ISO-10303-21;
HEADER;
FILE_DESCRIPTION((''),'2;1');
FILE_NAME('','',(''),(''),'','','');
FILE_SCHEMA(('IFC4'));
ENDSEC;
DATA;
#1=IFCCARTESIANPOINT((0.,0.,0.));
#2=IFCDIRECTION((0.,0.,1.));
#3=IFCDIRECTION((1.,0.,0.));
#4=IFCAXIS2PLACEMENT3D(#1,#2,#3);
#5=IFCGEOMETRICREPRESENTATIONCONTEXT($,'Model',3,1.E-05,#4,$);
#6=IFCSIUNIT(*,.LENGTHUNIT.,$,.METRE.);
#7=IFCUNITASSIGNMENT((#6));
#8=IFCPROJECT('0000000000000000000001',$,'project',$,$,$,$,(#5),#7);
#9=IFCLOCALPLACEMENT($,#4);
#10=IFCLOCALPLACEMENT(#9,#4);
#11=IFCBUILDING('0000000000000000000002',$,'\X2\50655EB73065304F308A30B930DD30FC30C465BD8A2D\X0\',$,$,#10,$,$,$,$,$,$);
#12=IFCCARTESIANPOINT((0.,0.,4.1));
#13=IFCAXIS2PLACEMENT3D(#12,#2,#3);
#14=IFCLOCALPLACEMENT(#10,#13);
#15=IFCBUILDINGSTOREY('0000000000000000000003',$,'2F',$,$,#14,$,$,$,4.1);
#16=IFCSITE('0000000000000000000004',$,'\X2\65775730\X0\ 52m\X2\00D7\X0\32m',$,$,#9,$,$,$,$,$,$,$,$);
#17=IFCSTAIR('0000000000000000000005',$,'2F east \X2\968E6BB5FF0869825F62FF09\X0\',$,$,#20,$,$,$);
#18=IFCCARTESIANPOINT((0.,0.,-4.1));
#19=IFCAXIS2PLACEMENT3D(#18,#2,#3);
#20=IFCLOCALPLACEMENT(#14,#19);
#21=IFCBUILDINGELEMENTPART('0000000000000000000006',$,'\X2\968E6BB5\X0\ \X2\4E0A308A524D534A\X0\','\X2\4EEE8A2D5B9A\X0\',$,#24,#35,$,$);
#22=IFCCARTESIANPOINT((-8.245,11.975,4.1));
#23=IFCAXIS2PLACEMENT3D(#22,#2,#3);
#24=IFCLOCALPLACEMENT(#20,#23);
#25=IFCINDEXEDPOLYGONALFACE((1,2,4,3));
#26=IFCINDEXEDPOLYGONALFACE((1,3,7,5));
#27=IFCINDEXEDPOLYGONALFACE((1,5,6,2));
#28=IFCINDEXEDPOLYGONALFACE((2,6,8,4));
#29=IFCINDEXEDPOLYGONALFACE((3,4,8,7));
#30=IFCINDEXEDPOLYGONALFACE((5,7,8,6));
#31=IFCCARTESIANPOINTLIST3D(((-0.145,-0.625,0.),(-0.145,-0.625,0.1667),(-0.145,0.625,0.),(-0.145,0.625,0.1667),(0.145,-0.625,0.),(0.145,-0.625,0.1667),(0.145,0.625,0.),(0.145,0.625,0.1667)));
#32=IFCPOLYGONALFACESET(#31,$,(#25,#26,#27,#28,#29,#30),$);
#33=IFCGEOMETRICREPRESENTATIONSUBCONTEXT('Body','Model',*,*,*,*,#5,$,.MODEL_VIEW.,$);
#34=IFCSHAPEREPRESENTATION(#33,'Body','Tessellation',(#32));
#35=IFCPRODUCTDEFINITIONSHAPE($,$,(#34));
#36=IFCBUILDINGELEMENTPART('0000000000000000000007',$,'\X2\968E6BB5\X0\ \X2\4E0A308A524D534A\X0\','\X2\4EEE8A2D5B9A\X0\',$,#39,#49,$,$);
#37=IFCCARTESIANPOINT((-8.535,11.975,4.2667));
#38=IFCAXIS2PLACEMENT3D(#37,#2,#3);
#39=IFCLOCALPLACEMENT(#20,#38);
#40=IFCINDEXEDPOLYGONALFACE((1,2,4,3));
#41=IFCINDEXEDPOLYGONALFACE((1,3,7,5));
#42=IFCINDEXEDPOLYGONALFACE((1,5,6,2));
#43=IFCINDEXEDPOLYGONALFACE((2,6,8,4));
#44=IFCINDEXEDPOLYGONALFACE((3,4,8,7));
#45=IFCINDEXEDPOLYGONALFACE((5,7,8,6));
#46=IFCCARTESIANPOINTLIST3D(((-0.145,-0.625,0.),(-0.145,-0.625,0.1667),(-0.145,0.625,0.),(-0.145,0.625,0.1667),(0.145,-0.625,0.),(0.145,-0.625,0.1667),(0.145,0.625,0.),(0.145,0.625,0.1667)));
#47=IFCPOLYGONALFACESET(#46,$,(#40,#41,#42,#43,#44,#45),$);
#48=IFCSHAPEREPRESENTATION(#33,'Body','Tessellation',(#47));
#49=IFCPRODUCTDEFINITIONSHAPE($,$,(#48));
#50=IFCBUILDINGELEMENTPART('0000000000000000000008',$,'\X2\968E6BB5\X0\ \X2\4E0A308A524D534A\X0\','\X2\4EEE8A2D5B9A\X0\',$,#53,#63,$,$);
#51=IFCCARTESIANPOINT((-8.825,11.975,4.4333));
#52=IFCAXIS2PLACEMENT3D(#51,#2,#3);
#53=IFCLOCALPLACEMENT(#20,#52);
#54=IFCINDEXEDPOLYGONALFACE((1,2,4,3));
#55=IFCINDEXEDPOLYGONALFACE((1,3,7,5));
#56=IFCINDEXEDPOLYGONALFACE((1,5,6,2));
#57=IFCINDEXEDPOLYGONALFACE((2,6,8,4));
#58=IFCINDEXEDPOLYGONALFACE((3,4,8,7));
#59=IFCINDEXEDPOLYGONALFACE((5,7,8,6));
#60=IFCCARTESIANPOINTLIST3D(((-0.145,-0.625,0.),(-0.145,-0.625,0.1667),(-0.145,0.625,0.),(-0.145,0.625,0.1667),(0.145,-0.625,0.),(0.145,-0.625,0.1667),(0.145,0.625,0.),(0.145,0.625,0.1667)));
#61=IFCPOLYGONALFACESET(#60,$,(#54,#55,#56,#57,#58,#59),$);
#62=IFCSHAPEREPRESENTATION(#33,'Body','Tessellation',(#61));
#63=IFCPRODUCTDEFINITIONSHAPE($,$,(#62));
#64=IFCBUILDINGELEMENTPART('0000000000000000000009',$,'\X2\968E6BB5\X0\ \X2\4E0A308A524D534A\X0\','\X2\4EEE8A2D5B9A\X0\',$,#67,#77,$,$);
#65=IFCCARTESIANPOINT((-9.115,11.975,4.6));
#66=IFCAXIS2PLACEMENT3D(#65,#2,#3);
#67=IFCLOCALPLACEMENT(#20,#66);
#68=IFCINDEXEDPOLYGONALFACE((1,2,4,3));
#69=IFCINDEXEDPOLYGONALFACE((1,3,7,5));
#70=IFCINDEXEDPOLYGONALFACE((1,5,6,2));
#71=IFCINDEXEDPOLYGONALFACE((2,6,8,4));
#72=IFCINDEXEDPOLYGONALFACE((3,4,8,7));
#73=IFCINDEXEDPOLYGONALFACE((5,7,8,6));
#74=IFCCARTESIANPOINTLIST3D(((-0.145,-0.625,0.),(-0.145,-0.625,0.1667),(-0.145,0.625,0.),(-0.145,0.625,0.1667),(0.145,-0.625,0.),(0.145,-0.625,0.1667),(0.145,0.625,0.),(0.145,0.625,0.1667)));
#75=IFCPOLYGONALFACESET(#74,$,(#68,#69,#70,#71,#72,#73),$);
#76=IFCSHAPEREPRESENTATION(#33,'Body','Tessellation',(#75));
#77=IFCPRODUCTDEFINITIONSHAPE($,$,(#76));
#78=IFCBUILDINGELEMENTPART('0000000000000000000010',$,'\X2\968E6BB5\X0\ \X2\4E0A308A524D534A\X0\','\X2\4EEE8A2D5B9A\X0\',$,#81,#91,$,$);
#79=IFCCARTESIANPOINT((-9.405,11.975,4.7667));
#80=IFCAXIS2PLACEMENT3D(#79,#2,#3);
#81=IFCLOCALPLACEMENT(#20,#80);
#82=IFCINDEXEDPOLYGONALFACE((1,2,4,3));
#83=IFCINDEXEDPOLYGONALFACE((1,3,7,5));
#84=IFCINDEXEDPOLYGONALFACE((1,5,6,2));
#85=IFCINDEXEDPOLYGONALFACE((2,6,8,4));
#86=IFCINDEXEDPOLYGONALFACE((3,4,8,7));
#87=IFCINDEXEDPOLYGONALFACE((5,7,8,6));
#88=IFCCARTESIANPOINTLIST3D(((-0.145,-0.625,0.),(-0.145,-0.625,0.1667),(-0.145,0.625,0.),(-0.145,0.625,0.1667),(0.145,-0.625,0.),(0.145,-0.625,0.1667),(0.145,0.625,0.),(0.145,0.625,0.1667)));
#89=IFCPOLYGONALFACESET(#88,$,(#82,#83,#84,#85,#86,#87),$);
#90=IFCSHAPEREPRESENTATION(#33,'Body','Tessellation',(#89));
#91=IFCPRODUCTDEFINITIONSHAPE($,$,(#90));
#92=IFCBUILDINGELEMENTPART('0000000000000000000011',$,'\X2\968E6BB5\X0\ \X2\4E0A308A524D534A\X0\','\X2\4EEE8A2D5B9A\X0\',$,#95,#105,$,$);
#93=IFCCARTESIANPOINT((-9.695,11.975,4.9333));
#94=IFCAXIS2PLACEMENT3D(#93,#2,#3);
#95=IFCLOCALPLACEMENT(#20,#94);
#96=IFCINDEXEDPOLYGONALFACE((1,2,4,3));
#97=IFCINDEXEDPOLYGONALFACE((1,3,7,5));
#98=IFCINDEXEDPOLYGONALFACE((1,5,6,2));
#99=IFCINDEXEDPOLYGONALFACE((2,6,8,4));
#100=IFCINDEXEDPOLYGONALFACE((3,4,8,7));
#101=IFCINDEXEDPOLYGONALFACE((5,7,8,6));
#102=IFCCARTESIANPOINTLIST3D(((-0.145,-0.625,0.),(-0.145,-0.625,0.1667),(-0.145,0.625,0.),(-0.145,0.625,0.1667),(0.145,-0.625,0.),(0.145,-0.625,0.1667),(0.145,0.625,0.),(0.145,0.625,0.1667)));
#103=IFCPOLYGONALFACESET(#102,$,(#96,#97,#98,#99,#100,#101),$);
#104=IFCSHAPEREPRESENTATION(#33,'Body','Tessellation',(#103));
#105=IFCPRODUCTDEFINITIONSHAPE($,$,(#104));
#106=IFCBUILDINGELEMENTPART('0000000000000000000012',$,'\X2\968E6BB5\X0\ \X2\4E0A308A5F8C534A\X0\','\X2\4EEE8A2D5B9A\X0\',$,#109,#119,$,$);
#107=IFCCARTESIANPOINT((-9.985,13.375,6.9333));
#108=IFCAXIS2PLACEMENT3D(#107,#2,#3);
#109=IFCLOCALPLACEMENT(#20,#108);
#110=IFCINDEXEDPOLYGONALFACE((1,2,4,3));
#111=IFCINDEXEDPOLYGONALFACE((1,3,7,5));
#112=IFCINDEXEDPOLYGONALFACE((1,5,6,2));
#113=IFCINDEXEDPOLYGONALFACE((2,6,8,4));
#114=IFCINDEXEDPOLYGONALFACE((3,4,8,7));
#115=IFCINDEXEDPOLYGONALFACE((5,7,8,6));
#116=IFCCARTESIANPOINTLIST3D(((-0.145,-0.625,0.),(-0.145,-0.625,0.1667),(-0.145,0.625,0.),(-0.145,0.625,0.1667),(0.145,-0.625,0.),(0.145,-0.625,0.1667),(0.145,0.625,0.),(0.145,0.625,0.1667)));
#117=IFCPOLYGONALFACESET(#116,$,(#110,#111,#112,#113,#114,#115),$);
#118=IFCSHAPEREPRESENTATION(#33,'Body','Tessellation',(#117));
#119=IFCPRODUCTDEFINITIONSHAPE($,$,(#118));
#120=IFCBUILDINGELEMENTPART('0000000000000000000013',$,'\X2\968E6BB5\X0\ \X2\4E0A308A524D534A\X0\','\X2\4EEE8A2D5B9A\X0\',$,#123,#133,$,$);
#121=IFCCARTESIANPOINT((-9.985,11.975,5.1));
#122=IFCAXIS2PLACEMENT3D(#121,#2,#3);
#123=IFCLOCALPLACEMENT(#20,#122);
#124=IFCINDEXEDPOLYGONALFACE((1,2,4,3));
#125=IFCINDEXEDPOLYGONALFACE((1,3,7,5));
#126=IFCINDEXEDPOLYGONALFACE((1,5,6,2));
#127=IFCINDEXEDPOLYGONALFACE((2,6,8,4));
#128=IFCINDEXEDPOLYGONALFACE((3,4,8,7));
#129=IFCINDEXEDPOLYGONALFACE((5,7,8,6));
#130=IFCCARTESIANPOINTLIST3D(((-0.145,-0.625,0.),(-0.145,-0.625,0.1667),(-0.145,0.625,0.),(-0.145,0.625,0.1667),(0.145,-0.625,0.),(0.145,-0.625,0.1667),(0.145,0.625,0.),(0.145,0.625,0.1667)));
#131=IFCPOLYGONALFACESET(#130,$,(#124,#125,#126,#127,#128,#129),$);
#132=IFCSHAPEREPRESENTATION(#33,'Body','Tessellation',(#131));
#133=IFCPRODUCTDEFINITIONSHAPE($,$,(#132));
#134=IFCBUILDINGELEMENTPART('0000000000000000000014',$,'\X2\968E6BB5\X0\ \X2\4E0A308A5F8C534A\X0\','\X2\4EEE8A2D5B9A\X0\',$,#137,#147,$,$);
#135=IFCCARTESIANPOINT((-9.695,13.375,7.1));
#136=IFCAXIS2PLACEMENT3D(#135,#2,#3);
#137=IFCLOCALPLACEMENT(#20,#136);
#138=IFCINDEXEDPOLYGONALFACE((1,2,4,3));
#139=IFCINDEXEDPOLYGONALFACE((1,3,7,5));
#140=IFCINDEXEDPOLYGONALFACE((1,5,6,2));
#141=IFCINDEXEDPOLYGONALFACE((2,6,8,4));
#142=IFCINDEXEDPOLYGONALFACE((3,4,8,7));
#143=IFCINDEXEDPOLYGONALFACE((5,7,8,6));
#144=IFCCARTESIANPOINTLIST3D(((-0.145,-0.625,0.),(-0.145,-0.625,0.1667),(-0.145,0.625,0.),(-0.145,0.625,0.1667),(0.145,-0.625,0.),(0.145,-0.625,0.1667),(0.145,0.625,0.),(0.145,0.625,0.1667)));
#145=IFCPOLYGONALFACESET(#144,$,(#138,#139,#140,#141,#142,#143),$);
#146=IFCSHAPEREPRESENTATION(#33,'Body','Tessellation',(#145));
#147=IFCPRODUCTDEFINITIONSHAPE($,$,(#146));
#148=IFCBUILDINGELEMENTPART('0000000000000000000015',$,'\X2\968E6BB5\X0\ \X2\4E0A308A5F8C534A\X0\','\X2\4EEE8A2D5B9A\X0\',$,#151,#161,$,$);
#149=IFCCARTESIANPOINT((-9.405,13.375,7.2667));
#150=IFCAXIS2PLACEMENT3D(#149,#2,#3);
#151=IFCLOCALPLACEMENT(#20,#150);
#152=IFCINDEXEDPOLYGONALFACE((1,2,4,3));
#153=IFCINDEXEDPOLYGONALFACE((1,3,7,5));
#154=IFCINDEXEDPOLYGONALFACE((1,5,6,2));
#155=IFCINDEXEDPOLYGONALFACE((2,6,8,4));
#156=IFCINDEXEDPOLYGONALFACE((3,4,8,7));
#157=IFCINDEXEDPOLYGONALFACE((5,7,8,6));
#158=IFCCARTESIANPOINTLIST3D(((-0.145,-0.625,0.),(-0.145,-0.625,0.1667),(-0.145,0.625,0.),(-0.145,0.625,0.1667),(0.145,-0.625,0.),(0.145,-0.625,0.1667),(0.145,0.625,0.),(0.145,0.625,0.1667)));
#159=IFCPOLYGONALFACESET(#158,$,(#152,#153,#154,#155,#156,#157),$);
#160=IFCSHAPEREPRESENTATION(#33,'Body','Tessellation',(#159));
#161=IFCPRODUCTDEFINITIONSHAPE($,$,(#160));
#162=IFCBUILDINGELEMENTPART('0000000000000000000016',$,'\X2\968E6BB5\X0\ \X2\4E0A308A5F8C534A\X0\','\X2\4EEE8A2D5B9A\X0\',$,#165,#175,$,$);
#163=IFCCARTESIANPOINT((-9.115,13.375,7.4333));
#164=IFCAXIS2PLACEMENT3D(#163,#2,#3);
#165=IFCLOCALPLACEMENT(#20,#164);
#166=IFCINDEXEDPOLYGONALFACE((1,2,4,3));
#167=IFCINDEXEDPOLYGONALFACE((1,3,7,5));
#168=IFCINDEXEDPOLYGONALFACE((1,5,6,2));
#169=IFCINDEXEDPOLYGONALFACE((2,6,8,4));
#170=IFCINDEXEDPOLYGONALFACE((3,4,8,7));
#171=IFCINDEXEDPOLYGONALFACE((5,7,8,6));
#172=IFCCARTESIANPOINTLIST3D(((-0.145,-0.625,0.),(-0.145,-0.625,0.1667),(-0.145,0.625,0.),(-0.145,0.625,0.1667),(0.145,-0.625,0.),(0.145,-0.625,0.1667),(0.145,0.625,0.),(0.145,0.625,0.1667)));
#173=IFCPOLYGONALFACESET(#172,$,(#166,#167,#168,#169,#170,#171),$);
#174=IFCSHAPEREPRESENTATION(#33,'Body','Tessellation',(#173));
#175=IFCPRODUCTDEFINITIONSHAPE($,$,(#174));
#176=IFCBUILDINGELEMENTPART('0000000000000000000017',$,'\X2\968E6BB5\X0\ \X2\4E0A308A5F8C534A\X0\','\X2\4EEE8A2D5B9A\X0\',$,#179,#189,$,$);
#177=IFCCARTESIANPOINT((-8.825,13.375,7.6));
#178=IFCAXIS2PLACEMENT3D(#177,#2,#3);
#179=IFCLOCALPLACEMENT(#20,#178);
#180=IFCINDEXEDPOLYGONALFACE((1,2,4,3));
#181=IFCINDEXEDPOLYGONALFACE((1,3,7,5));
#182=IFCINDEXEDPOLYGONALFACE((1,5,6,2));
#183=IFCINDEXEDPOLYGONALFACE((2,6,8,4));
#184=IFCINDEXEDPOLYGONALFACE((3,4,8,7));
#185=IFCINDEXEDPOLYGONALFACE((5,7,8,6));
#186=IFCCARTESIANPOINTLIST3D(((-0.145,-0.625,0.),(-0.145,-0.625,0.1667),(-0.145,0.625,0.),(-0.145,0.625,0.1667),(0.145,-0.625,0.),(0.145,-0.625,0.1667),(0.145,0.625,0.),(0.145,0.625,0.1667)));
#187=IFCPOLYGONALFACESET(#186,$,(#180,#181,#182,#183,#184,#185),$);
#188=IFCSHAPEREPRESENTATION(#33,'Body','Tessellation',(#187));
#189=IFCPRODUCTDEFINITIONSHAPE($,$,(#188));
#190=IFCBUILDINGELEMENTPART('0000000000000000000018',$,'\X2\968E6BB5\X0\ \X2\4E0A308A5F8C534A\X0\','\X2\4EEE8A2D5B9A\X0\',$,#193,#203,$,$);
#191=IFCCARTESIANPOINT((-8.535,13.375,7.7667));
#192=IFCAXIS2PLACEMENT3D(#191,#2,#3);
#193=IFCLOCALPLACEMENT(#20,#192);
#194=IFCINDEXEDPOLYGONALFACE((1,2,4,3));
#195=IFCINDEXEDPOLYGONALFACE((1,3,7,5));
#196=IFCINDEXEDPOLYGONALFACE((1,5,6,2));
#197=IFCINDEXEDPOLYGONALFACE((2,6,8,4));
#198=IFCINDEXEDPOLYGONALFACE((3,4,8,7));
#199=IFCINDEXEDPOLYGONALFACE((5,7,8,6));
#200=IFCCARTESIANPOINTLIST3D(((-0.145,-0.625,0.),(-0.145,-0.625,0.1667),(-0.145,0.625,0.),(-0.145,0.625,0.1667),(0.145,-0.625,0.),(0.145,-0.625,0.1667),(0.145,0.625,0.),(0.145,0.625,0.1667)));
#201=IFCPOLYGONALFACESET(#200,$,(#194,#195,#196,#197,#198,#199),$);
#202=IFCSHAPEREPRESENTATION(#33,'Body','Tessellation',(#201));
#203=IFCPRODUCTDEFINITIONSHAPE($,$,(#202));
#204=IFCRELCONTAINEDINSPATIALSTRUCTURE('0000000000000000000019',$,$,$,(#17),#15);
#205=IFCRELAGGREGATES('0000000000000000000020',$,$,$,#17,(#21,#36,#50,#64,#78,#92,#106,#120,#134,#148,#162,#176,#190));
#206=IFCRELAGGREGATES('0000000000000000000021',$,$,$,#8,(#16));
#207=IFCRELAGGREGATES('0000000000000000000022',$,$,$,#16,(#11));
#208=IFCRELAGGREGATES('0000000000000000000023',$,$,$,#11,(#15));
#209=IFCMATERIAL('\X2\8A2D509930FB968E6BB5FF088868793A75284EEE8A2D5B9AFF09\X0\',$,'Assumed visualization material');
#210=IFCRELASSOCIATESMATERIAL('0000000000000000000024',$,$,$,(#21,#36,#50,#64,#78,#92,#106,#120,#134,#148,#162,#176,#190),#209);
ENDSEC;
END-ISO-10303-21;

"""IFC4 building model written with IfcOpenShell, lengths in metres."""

from ifc_helpers import new_model, si_unit, frame, origin_with_axes, place, context, subcontext, project, spatial, rectangle, extrude, material, element, aggregate, save


model = new_model("IFC4")

# Units and contexts
model_context = context("Model", 3, precision=1e-05, world=origin_with_axes())
body_context = subcontext(model_context, "Body", "Model", "MODEL_VIEW")
ifc_project = project(units=[si_unit("LENGTHUNIT", "METRE")], contexts=[model_context])

# Site, building, storey
site_placement = place(None, origin_with_axes())
site = spatial("IfcSite", under=ifc_project, at=site_placement, Name="敷地 52m×32m")
building_placement = place(site_placement, origin_with_axes())
building = spatial("IfcBuilding", under=site, at=building_placement, Name="健康づくりスポーツ施設")
storey_placement = place(building_placement, frame((0.0, 0.0, 4.1), z_axis=(0.0, 0.0, 1.0), x_axis=(1.0, 0.0, 0.0)))
storey = spatial("IfcBuildingStorey", under=building, at=storey_placement, Name="2F", Elevation=4.1)

# Stair, building element parts
stair_placement = place(storey_placement, frame((0.0, 0.0, -4.1), z_axis=(0.0, 0.0, 1.0), x_axis=(1.0, 0.0, 0.0)))
stair = element("IfcStair", 1, at=stair_placement, inside=storey, Name="2F east 階段（概形）")
ifc_material_1 = material(Name="設備・階段（表示用仮設定）", Category="Assumed visualization material")
building_element_part_1_placement = place(stair_placement, frame((-8.245, 11.975, 4.1), z_axis=(0.0, 0.0, 1.0), x_axis=(1.0, 0.0, 0.0)))
building_element_part_1 = element("IfcBuildingElementPart", 2, at=building_element_part_1_placement, material=ifc_material_1, Name="階段 上り前半", Description="仮設定", context=body_context, shape_type="SweptSolid", body=[
    extrude(rectangle(XDim=0.29, YDim=1.25), origin_with_axes(), (0.0, 0.0, 1.0), 0.1667),
])
building_element_part_2_placement = place(stair_placement, frame((-8.535, 11.975, 4.2667), z_axis=(0.0, 0.0, 1.0), x_axis=(1.0, 0.0, 0.0)))
building_element_part_2 = element("IfcBuildingElementPart", 3, at=building_element_part_2_placement, material=ifc_material_1, Name="階段 上り前半", Description="仮設定", context=body_context, shape_type="SweptSolid", body=[
    extrude(rectangle(XDim=0.29, YDim=1.25), origin_with_axes(), (0.0, 0.0, 1.0), 0.1667),
])
building_element_part_3_placement = place(stair_placement, frame((-8.825, 11.975, 4.4333), z_axis=(0.0, 0.0, 1.0), x_axis=(1.0, 0.0, 0.0)))
building_element_part_3 = element("IfcBuildingElementPart", 4, at=building_element_part_3_placement, material=ifc_material_1, Name="階段 上り前半", Description="仮設定", context=body_context, shape_type="SweptSolid", body=[
    extrude(rectangle(XDim=0.29, YDim=1.25), origin_with_axes(), (0.0, 0.0, 1.0), 0.1667),
])
building_element_part_4_placement = place(stair_placement, frame((-9.115, 11.975, 4.6), z_axis=(0.0, 0.0, 1.0), x_axis=(1.0, 0.0, 0.0)))
building_element_part_4 = element("IfcBuildingElementPart", 5, at=building_element_part_4_placement, material=ifc_material_1, Name="階段 上り前半", Description="仮設定", context=body_context, shape_type="SweptSolid", body=[
    extrude(rectangle(XDim=0.29, YDim=1.25), origin_with_axes(), (0.0, 0.0, 1.0), 0.1667),
])
building_element_part_5_placement = place(stair_placement, frame((-9.405, 11.975, 4.7667), z_axis=(0.0, 0.0, 1.0), x_axis=(1.0, 0.0, 0.0)))
building_element_part_5 = element("IfcBuildingElementPart", 6, at=building_element_part_5_placement, material=ifc_material_1, Name="階段 上り前半", Description="仮設定", context=body_context, shape_type="SweptSolid", body=[
    extrude(rectangle(XDim=0.29, YDim=1.25), origin_with_axes(), (0.0, 0.0, 1.0), 0.1667),
])
building_element_part_6_placement = place(stair_placement, frame((-9.695, 11.975, 4.9333), z_axis=(0.0, 0.0, 1.0), x_axis=(1.0, 0.0, 0.0)))
building_element_part_6 = element("IfcBuildingElementPart", 7, at=building_element_part_6_placement, material=ifc_material_1, Name="階段 上り前半", Description="仮設定", context=body_context, shape_type="SweptSolid", body=[
    extrude(rectangle(XDim=0.29, YDim=1.25), origin_with_axes(), (0.0, 0.0, 1.0), 0.1667),
])
building_element_part_7_placement = place(stair_placement, frame((-9.985, 13.375, 6.9333), z_axis=(0.0, 0.0, 1.0), x_axis=(1.0, 0.0, 0.0)))
building_element_part_7 = element("IfcBuildingElementPart", 8, at=building_element_part_7_placement, material=ifc_material_1, Name="階段 上り後半", Description="仮設定", context=body_context, shape_type="SweptSolid", body=[
    extrude(rectangle(XDim=0.29, YDim=1.25), origin_with_axes(), (0.0, 0.0, 1.0), 0.1667),
])
building_element_part_8_placement = place(stair_placement, frame((-9.985, 11.975, 5.1), z_axis=(0.0, 0.0, 1.0), x_axis=(1.0, 0.0, 0.0)))
building_element_part_8 = element("IfcBuildingElementPart", 9, at=building_element_part_8_placement, material=ifc_material_1, Name="階段 上り前半", Description="仮設定", context=body_context, shape_type="SweptSolid", body=[
    extrude(rectangle(XDim=0.29, YDim=1.25), origin_with_axes(), (0.0, 0.0, 1.0), 0.1667),
])
building_element_part_9_placement = place(stair_placement, frame((-9.695, 13.375, 7.1), z_axis=(0.0, 0.0, 1.0), x_axis=(1.0, 0.0, 0.0)))
building_element_part_9 = element("IfcBuildingElementPart", 10, at=building_element_part_9_placement, material=ifc_material_1, Name="階段 上り後半", Description="仮設定", context=body_context, shape_type="SweptSolid", body=[
    extrude(rectangle(XDim=0.29, YDim=1.25), origin_with_axes(), (0.0, 0.0, 1.0), 0.1667),
])
building_element_part_10_placement = place(stair_placement, frame((-9.405, 13.375, 7.2667), z_axis=(0.0, 0.0, 1.0), x_axis=(1.0, 0.0, 0.0)))
building_element_part_10 = element("IfcBuildingElementPart", 11, at=building_element_part_10_placement, material=ifc_material_1, Name="階段 上り後半", Description="仮設定", context=body_context, shape_type="SweptSolid", body=[
    extrude(rectangle(XDim=0.29, YDim=1.25), origin_with_axes(), (0.0, 0.0, 1.0), 0.1667),
])
building_element_part_11_placement = place(stair_placement, frame((-9.115, 13.375, 7.4333), z_axis=(0.0, 0.0, 1.0), x_axis=(1.0, 0.0, 0.0)))
building_element_part_11 = element("IfcBuildingElementPart", 12, at=building_element_part_11_placement, material=ifc_material_1, Name="階段 上り後半", Description="仮設定", context=body_context, shape_type="SweptSolid", body=[
    extrude(rectangle(XDim=0.29, YDim=1.25), origin_with_axes(), (0.0, 0.0, 1.0), 0.1667),
])
building_element_part_12_placement = place(stair_placement, frame((-8.825, 13.375, 7.6), z_axis=(0.0, 0.0, 1.0), x_axis=(1.0, 0.0, 0.0)))
building_element_part_12 = element("IfcBuildingElementPart", 13, at=building_element_part_12_placement, material=ifc_material_1, Name="階段 上り後半", Description="仮設定", context=body_context, shape_type="SweptSolid", body=[
    extrude(rectangle(XDim=0.29, YDim=1.25), origin_with_axes(), (0.0, 0.0, 1.0), 0.1667),
])
building_element_part_13_placement = place(stair_placement, frame((-8.535, 13.375, 7.7667), z_axis=(0.0, 0.0, 1.0), x_axis=(1.0, 0.0, 0.0)))
building_element_part_13 = element("IfcBuildingElementPart", 14, at=building_element_part_13_placement, material=ifc_material_1, Name="階段 上り後半", Description="仮設定", context=body_context, shape_type="SweptSolid", body=[
    extrude(rectangle(XDim=0.29, YDim=1.25), origin_with_axes(), (0.0, 0.0, 1.0), 0.1667),
])
aggregate(stair, [building_element_part_1, building_element_part_2, building_element_part_3, building_element_part_4, building_element_part_5, building_element_part_6, building_element_part_7, building_element_part_8, building_element_part_9, building_element_part_10, building_element_part_11, building_element_part_12, building_element_part_13])

save(model, "model.ifc")
